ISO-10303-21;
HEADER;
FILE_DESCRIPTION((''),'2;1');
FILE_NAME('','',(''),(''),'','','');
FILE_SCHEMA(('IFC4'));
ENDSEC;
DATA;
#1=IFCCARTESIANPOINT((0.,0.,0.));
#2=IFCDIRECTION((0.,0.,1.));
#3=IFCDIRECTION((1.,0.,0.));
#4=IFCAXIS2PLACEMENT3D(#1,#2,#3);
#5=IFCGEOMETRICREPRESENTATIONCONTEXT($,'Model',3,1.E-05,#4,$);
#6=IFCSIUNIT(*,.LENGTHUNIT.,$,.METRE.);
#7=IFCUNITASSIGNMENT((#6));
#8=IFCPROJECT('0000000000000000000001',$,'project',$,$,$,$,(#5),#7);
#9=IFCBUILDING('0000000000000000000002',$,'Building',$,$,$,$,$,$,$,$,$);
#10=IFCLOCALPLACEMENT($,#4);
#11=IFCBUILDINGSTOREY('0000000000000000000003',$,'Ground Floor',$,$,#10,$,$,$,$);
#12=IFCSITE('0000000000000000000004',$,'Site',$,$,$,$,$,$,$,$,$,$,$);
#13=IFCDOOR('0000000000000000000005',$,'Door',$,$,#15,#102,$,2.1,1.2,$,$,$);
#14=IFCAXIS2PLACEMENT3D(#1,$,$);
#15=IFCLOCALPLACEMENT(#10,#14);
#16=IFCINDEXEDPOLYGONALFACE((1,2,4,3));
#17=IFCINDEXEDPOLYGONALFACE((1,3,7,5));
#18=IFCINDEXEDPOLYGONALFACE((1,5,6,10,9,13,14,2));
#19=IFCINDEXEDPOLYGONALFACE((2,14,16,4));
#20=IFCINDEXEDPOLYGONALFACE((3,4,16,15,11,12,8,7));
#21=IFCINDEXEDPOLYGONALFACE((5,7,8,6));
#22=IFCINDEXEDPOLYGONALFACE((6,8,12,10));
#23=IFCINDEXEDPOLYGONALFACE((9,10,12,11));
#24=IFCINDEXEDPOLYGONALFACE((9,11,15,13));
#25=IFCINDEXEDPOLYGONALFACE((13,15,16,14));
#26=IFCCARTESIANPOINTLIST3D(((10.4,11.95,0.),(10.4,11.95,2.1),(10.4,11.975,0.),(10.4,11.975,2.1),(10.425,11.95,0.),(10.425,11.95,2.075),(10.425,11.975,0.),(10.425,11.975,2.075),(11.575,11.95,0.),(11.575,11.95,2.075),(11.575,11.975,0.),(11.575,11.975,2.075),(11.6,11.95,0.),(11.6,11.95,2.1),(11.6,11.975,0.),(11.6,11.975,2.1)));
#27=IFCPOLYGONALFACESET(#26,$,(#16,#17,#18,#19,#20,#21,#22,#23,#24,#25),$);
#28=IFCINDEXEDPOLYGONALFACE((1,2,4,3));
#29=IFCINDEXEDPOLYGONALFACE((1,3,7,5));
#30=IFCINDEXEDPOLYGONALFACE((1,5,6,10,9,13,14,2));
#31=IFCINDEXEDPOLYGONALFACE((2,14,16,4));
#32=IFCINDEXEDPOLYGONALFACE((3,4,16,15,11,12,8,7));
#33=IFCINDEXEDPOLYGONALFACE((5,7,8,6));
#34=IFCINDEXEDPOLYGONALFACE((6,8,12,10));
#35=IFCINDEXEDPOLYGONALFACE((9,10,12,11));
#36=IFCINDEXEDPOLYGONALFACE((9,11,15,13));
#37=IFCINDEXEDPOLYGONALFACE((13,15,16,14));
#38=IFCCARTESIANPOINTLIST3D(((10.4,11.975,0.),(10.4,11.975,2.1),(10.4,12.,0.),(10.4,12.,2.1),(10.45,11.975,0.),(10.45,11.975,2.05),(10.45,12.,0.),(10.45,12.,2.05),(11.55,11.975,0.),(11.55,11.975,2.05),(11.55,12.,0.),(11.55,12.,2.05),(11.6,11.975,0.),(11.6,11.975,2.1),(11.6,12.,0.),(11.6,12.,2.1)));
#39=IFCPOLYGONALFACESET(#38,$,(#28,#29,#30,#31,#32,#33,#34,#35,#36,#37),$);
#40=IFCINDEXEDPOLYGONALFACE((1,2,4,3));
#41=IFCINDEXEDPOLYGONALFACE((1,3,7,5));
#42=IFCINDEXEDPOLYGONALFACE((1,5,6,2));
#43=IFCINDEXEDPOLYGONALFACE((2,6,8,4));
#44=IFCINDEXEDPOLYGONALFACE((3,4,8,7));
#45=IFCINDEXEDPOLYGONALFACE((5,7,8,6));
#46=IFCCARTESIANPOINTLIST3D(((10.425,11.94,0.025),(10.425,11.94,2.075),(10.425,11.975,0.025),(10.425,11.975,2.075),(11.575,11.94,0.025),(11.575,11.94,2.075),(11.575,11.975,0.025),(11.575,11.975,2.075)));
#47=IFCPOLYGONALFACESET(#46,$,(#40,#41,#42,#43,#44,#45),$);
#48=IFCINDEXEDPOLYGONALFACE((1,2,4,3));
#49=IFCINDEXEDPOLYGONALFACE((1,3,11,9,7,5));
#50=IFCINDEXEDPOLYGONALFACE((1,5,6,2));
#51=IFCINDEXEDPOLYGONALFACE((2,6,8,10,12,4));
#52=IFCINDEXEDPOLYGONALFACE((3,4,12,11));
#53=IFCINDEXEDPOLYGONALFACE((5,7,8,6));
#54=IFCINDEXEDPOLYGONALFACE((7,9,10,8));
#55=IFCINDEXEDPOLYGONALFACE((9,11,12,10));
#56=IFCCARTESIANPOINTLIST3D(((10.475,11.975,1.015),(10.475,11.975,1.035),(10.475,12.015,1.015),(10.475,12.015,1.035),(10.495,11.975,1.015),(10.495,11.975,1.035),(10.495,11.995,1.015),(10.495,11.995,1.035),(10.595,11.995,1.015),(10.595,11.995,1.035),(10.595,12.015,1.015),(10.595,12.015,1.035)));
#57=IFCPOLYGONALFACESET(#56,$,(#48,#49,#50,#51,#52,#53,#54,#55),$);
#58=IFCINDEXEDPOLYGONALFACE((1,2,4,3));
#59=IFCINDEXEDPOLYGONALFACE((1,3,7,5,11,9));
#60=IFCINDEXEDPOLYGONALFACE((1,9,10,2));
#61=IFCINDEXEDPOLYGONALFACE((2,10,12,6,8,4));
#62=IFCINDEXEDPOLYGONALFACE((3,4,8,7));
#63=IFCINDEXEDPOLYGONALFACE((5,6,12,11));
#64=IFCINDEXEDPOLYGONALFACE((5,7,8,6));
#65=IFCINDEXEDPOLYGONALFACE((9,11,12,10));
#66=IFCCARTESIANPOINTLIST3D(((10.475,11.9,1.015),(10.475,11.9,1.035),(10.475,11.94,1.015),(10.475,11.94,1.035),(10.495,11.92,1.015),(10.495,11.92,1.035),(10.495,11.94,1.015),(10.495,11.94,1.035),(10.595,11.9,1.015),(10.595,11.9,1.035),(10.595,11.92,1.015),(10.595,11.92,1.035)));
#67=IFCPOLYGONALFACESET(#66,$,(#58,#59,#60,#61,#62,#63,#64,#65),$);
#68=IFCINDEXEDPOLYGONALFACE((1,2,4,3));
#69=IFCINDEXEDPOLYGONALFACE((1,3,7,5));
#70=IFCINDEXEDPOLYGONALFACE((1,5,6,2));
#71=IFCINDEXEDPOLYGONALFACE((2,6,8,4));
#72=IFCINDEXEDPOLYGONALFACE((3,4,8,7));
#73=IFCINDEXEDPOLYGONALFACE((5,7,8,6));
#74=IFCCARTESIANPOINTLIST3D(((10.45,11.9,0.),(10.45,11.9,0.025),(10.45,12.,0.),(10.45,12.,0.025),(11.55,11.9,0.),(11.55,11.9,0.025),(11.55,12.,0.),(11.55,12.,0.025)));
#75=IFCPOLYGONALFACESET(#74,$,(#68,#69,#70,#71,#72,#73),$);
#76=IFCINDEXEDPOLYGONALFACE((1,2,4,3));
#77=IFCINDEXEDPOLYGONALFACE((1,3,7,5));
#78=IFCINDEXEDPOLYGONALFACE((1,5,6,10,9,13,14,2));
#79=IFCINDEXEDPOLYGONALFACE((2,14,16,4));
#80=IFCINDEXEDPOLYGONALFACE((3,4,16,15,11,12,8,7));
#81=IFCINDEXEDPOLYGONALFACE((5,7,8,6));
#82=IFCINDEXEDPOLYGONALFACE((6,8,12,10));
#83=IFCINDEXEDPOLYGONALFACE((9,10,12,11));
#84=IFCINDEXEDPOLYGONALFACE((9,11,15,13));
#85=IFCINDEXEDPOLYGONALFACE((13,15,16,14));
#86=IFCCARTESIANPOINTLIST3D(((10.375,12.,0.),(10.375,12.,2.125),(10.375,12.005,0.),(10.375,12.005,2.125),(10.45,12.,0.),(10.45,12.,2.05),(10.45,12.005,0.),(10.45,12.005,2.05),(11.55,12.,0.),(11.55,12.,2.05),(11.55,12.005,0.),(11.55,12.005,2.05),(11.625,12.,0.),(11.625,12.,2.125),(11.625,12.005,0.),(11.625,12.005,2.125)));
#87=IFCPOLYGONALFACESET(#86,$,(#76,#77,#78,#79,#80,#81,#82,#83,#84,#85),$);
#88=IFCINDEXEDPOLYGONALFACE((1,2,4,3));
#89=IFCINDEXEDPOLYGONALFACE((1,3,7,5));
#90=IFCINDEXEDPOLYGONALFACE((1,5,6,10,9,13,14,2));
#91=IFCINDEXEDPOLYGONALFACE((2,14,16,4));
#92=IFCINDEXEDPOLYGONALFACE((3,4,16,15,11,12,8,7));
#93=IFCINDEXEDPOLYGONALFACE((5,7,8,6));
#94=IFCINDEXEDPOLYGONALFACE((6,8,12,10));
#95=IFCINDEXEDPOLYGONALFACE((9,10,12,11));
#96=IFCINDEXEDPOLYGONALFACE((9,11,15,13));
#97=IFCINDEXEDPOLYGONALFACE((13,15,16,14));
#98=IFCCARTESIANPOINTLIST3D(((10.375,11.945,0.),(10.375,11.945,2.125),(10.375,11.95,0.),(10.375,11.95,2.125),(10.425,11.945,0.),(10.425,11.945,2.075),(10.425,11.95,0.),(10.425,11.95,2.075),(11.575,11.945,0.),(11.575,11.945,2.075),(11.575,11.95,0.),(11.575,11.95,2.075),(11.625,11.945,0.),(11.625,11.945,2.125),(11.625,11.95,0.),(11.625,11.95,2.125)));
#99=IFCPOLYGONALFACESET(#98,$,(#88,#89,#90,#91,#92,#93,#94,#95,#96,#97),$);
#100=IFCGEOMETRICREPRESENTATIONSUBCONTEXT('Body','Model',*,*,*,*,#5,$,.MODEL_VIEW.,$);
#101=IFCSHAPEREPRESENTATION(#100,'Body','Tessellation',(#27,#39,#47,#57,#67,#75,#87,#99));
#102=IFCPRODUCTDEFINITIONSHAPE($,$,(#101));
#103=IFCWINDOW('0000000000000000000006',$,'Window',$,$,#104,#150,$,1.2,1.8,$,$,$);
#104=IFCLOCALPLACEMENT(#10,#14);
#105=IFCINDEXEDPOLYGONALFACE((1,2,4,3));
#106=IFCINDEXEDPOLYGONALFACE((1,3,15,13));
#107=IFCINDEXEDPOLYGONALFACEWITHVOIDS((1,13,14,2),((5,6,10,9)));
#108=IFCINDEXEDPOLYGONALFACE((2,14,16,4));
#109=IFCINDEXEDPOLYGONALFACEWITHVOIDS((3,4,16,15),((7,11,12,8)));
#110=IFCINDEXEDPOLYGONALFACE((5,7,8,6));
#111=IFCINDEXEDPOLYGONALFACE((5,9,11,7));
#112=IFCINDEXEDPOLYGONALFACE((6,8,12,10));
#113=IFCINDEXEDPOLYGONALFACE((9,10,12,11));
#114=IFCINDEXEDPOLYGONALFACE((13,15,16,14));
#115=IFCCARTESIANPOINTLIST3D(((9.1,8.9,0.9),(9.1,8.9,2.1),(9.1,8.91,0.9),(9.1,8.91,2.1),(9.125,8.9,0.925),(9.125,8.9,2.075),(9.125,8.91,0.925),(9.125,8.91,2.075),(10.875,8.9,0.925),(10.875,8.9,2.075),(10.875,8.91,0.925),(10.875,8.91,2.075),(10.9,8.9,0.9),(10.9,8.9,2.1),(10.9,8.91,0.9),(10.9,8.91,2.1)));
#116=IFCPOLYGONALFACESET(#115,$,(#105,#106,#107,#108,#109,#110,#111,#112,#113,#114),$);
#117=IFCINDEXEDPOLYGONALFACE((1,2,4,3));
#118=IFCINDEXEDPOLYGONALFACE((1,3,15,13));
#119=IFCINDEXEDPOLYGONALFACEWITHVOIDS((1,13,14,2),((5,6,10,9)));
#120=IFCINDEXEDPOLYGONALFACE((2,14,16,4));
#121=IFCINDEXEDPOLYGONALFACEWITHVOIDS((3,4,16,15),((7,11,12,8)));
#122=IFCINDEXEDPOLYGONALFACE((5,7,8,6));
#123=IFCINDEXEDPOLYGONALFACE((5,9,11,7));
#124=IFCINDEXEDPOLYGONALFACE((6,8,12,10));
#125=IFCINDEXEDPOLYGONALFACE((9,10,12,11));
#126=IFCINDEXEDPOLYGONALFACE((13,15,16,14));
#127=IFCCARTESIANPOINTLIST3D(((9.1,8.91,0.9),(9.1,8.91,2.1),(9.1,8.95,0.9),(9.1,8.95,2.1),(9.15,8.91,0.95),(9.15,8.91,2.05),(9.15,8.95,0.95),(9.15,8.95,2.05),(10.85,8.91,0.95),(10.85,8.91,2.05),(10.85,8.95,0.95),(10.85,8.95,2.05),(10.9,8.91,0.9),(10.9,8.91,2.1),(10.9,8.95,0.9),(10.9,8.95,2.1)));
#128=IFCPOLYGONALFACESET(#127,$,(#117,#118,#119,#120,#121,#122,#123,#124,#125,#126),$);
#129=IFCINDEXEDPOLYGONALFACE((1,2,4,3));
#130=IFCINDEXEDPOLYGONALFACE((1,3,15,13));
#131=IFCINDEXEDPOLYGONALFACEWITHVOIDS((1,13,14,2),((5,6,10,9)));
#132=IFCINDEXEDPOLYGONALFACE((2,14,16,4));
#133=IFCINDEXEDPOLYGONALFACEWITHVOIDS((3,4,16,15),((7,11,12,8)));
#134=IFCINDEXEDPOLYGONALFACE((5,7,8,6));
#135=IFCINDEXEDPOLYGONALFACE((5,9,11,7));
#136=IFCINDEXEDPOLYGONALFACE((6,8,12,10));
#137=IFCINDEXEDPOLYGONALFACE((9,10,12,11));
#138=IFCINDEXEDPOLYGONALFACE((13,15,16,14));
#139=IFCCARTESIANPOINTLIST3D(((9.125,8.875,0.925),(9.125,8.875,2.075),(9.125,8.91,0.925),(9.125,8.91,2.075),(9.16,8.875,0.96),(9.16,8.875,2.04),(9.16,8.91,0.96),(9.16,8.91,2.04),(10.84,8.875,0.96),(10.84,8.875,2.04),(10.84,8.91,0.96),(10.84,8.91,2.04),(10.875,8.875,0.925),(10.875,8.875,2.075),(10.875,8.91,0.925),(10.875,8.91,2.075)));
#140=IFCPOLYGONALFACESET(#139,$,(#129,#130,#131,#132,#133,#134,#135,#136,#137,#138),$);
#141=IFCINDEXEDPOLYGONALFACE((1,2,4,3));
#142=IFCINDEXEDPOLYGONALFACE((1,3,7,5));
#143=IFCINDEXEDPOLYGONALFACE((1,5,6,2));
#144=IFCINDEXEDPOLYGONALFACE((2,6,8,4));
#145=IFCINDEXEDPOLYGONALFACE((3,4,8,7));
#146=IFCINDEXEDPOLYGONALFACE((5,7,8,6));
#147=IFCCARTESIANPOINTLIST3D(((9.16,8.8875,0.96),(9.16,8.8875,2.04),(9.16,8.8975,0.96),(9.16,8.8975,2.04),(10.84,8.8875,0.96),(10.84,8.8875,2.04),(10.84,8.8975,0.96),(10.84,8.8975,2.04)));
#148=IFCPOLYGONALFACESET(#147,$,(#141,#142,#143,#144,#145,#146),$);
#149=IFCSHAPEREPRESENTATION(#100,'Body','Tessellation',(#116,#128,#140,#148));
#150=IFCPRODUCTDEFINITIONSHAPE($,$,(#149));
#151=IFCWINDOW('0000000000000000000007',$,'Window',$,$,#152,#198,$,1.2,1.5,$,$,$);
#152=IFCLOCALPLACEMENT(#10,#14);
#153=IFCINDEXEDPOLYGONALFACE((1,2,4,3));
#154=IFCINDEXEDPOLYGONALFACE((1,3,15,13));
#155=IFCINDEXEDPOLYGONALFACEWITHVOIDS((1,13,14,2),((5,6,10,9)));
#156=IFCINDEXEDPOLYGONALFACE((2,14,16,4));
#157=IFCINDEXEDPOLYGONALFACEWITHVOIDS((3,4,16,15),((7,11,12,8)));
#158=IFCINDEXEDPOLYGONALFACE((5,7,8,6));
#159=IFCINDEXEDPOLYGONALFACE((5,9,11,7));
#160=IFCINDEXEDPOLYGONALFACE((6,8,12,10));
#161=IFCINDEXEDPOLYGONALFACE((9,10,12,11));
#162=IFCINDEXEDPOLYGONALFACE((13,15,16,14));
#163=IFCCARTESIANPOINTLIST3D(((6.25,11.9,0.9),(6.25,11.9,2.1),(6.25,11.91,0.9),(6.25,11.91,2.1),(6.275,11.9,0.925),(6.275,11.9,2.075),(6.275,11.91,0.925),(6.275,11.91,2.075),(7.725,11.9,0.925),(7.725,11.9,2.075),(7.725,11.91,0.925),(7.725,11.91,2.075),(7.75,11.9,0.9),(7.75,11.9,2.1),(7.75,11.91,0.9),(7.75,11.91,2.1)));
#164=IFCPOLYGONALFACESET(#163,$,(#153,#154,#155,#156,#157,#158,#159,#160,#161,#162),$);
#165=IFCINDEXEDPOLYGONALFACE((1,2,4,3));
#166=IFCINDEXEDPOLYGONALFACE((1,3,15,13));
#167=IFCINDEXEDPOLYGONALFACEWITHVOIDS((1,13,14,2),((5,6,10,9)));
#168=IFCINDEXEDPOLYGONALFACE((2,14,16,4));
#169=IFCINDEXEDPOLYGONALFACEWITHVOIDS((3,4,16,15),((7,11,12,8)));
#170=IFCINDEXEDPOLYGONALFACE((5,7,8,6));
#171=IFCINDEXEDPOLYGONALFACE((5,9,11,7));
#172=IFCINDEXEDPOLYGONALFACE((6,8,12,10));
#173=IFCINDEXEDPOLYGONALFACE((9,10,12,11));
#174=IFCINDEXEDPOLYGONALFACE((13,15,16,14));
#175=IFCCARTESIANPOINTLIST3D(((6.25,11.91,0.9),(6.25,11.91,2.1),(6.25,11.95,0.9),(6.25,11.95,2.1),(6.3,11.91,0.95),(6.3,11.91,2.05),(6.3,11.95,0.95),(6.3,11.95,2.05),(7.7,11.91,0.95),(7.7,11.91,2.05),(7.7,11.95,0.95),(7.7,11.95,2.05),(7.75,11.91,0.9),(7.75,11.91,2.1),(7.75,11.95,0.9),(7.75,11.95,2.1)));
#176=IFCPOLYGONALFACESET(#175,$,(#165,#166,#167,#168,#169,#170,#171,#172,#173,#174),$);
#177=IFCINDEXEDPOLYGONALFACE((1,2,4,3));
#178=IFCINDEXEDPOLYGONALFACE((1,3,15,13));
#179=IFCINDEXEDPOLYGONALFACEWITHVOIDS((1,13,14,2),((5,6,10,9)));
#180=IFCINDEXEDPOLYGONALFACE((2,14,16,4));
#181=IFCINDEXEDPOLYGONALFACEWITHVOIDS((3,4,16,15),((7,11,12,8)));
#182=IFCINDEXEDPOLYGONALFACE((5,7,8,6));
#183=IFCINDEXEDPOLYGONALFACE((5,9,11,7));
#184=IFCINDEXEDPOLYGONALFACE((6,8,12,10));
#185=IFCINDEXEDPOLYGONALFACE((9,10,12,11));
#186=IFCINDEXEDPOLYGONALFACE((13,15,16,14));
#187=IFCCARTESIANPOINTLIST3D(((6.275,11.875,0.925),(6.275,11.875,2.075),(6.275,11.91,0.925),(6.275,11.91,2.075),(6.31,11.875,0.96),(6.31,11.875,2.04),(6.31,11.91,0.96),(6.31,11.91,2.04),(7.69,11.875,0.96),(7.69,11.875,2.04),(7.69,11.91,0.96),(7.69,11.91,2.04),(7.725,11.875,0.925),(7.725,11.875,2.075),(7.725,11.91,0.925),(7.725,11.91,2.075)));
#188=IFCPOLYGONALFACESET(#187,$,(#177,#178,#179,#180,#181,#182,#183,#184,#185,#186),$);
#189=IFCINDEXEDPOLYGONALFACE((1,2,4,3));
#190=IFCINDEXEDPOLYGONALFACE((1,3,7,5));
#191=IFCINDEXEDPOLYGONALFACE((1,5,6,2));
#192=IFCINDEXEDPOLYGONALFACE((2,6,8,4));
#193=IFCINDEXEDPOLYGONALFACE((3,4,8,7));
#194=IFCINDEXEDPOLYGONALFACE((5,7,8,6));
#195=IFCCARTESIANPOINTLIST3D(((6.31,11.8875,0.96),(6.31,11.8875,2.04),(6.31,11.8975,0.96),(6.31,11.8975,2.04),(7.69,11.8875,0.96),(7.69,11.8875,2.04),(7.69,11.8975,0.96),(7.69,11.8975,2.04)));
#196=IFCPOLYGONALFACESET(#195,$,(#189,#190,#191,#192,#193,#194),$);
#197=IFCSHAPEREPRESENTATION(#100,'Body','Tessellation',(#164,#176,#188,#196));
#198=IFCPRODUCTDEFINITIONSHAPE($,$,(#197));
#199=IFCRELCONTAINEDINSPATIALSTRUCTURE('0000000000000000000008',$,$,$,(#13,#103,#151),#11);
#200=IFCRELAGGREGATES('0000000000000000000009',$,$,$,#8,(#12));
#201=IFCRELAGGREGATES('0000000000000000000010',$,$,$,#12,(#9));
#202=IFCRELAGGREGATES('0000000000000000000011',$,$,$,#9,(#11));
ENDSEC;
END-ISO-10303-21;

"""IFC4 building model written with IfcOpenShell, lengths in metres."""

from ifc_helpers import new_model, si_unit, frame, origin_with_axes, place, context, subcontext, project, spatial, line, indexed_curve, outline, extrude, element, save


model = new_model("IFC4")

# Units and contexts
model_context = context("Model", 3, precision=1e-05, world=origin_with_axes())
body_context = subcontext(model_context, "Body", "Model", "MODEL_VIEW")
ifc_project = project(units=[si_unit("LENGTHUNIT", "METRE")], contexts=[model_context])

# Site, building, storey
site = spatial("IfcSite", under=ifc_project, Name="Site")
building = spatial("IfcBuilding", under=site, Name="Building")
storey_placement = place(None, origin_with_axes())
storey = spatial("IfcBuildingStorey", under=building, at=storey_placement, Name="Ground Floor")

# Door
door_1_placement = place(storey_placement, frame((11.6, 12.0, 0.0), z_axis=(0.0, 0.0, 1.0), x_axis=(-1.0, 0.0, 0.0)))
element("IfcDoor", 1, at=door_1_placement, inside=storey, Name="Door", OverallHeight=2.1, OverallWidth=1.2, context=body_context, shape_type="SweptSolid", body=[
    extrude(outline(indexed_curve([(0.0, 0.0), (0.0, 2.1), (1.2, 2.1), (1.2, 0.0), (1.175, 0.0), (1.175, 2.075), (0.025, 2.075), (0.025, 0.0)], segments=[line(1, 2, 3, 4, 5, 6, 7, 8, 1)])), frame((0.0, 0.025, 0.0), z_axis=(0.0, -1.0, 0.0), x_axis=(1.0, 0.0, 0.0)), (0.0, 0.0, -1.0), 0.025),
    extrude(outline(indexed_curve([(0.0, 0.0), (0.0, 2.1), (1.2, 2.1), (1.2, 0.0), (1.15, 0.0), (1.15, 2.05), (0.05, 2.05), (0.05, 0.0)], segments=[line(1, 2, 3, 4, 5, 6, 7, 8, 1)])), frame((0.0, 0.0, 0.0), z_axis=(0.0, -1.0, 0.0), x_axis=(1.0, 0.0, 0.0)), (0.0, 0.0, -1.0), 0.025),
    extrude(outline(indexed_curve([(0.0, 0.0), (1.15, 0.0), (1.15, 0.035), (0.0, 0.035)], segments=[line(1, 2, 3, 4, 1)])), frame((0.025, 0.025, 0.025), z_axis=(0.0, 0.0, 1.0), x_axis=(1.0, 0.0, 0.0)), (0.0, 0.0, 1.0), 2.05),
    extrude(outline(indexed_curve([(0.0, 0.0), (0.0, -0.04), (-0.12, -0.04), (-0.12, -0.02), (-0.02, -0.02), (-0.02, 0.0)], segments=[line(1, 2, 3, 4, 5, 6, 1)])), frame((1.125, 0.025, 1.015), z_axis=(0.0, 0.0, 1.0), x_axis=(1.0, 0.0, 0.0)), (0.0, 0.0, 1.0), 0.02),
    extrude(outline(indexed_curve([(0.0, 0.0), (0.0, 0.04), (-0.12, 0.04), (-0.12, 0.02), (-0.02, 0.02), (-0.02, 0.0)], segments=[line(1, 2, 3, 4, 5, 6, 1)])), frame((1.125, 0.06, 1.015), z_axis=(0.0, 0.0, 1.0), x_axis=(1.0, 0.0, 0.0)), (0.0, 0.0, 1.0), 0.02),
    extrude(outline(indexed_curve([(0.0, 0.0), (1.1, 0.0), (1.1, 0.1), (0.0, 0.1)], segments=[line(1, 2, 3, 4, 1)])), frame((0.05, 0.0, 0.0), z_axis=(0.0, 0.0, 1.0), x_axis=(1.0, 0.0, 0.0)), (0.0, 0.0, 1.0), 0.025),
    extrude(outline(indexed_curve([(0.0, 0.0), (0.0, 2.125), (1.25, 2.125), (1.25, 0.0), (1.175, 0.0), (1.175, 2.05), (0.075, 2.05), (0.075, 0.0)], segments=[line(1, 2, 3, 4, 5, 6, 7, 8, 1)])), frame((-0.025, -0.005, 0.0), z_axis=(0.0, -1.0, 0.0), x_axis=(1.0, 0.0, 0.0)), (0.0, 0.0, -1.0), 0.005),
    extrude(outline(indexed_curve([(0.0, 0.0), (0.0, 2.125), (1.25, 2.125), (1.25, 0.0), (1.2, 0.0), (1.2, 2.075), (0.05, 2.075), (0.05, 0.0)], segments=[line(1, 2, 3, 4, 5, 6, 7, 8, 1)])), frame((-0.025, 0.05, 0.0), z_axis=(0.0, -1.0, 0.0), x_axis=(1.0, 0.0, 0.0)), (0.0, 0.0, -1.0), 0.005),
])

# Windows
window_1_placement = place(storey_placement, frame((10.9, 9.0, 0.9), z_axis=(0.0, 0.0, 1.0), x_axis=(-1.0, 0.0, 0.0)))
element("IfcWindow", 2, at=window_1_placement, inside=storey, Name="Window", OverallHeight=1.2, OverallWidth=1.8, context=body_context, shape_type="SweptSolid", body=[
    extrude(outline(indexed_curve([(0.0, 0.0), (1.8, 0.0), (1.8, 1.2), (0.0, 1.2)], segments=[line(1, 2, 3, 4, 1)]), holes=[indexed_curve([(0.025, 0.025), (1.775, 0.025), (1.775, 1.175), (0.025, 1.175)], segments=[line(1, 2, 3, 4, 1)])]), frame((0.0, 0.09, 0.0), z_axis=(0.0, -1.0, 0.0), x_axis=(1.0, 0.0, 0.0)), (0.0, 0.0, -1.0), 0.01),
    extrude(outline(indexed_curve([(0.0, 0.0), (1.8, 0.0), (1.8, 1.2), (0.0, 1.2)], segments=[line(1, 2, 3, 4, 1)]), holes=[indexed_curve([(0.05, 0.05), (1.75, 0.05), (1.75, 1.15), (0.05, 1.15)], segments=[line(1, 2, 3, 4, 1)])]), frame((0.0, 0.05, 0.0), z_axis=(0.0, -1.0, 0.0), x_axis=(1.0, 0.0, 0.0)), (0.0, 0.0, -1.0), 0.04),
    extrude(outline(indexed_curve([(0.0, 0.0), (1.75, 0.0), (1.75, 1.15), (0.0, 1.15)], segments=[line(1, 2, 3, 4, 1)]), holes=[indexed_curve([(0.035, 0.035), (1.715, 0.035), (1.715, 1.115), (0.035, 1.115)], segments=[line(1, 2, 3, 4, 1)])]), frame((0.025, 0.09, 0.025), z_axis=(0.0, -1.0, 0.0), x_axis=(1.0, 0.0, 0.0)), (0.0, 0.0, -1.0), 0.035),
    extrude(outline(indexed_curve([(0.035, 0.035), (1.715, 0.035), (1.715, 1.115), (0.035, 1.115)], segments=[line(1, 2, 3, 4, 1)])), frame((0.025, 0.1025, 0.025), z_axis=(0.0, -1.0, 0.0), x_axis=(1.0, 0.0, 0.0)), (0.0, 0.0, -1.0), 0.01),
])
for number, where, z_axis, x_axis, name in (
    (3, (7.75, 12.0, 0.9), (0.0, 0.0, 1.0), (-1.0, 0.0, 0.0), "Window"),
):
    element("IfcWindow", number, at=place(storey_placement, frame(where, z_axis=z_axis, x_axis=x_axis)), inside=storey, Name=name, OverallHeight=1.2, OverallWidth=1.5, context=body_context, shape_type="SweptSolid", body=[
        extrude(outline(indexed_curve([(0.0, 0.0), (1.5, 0.0), (1.5, 1.2), (0.0, 1.2)], segments=[line(1, 2, 3, 4, 1)]), holes=[indexed_curve([(0.025, 0.025), (1.475, 0.025), (1.475, 1.175), (0.025, 1.175)], segments=[line(1, 2, 3, 4, 1)])]), frame((0.0, 0.09, 0.0), z_axis=(0.0, -1.0, 0.0), x_axis=(1.0, 0.0, 0.0)), (0.0, 0.0, -1.0), 0.01),
        extrude(outline(indexed_curve([(0.0, 0.0), (1.5, 0.0), (1.5, 1.2), (0.0, 1.2)], segments=[line(1, 2, 3, 4, 1)]), holes=[indexed_curve([(0.05, 0.05), (1.45, 0.05), (1.45, 1.15), (0.05, 1.15)], segments=[line(1, 2, 3, 4, 1)])]), frame((0.0, 0.05, 0.0), z_axis=(0.0, -1.0, 0.0), x_axis=(1.0, 0.0, 0.0)), (0.0, 0.0, -1.0), 0.04),
        extrude(outline(indexed_curve([(0.0, 0.0), (1.45, 0.0), (1.45, 1.15), (0.0, 1.15)], segments=[line(1, 2, 3, 4, 1)]), holes=[indexed_curve([(0.035, 0.035), (1.415, 0.035), (1.415, 1.115), (0.035, 1.115)], segments=[line(1, 2, 3, 4, 1)])]), frame((0.025, 0.09, 0.025), z_axis=(0.0, -1.0, 0.0), x_axis=(1.0, 0.0, 0.0)), (0.0, 0.0, -1.0), 0.035),
        extrude(outline(indexed_curve([(0.035, 0.035), (1.415, 0.035), (1.415, 1.115), (0.035, 1.115)], segments=[line(1, 2, 3, 4, 1)])), frame((0.025, 0.1025, 0.025), z_axis=(0.0, -1.0, 0.0), x_axis=(1.0, 0.0, 0.0)), (0.0, 0.0, -1.0), 0.01),
    ])

save(model, "model.ifc")
